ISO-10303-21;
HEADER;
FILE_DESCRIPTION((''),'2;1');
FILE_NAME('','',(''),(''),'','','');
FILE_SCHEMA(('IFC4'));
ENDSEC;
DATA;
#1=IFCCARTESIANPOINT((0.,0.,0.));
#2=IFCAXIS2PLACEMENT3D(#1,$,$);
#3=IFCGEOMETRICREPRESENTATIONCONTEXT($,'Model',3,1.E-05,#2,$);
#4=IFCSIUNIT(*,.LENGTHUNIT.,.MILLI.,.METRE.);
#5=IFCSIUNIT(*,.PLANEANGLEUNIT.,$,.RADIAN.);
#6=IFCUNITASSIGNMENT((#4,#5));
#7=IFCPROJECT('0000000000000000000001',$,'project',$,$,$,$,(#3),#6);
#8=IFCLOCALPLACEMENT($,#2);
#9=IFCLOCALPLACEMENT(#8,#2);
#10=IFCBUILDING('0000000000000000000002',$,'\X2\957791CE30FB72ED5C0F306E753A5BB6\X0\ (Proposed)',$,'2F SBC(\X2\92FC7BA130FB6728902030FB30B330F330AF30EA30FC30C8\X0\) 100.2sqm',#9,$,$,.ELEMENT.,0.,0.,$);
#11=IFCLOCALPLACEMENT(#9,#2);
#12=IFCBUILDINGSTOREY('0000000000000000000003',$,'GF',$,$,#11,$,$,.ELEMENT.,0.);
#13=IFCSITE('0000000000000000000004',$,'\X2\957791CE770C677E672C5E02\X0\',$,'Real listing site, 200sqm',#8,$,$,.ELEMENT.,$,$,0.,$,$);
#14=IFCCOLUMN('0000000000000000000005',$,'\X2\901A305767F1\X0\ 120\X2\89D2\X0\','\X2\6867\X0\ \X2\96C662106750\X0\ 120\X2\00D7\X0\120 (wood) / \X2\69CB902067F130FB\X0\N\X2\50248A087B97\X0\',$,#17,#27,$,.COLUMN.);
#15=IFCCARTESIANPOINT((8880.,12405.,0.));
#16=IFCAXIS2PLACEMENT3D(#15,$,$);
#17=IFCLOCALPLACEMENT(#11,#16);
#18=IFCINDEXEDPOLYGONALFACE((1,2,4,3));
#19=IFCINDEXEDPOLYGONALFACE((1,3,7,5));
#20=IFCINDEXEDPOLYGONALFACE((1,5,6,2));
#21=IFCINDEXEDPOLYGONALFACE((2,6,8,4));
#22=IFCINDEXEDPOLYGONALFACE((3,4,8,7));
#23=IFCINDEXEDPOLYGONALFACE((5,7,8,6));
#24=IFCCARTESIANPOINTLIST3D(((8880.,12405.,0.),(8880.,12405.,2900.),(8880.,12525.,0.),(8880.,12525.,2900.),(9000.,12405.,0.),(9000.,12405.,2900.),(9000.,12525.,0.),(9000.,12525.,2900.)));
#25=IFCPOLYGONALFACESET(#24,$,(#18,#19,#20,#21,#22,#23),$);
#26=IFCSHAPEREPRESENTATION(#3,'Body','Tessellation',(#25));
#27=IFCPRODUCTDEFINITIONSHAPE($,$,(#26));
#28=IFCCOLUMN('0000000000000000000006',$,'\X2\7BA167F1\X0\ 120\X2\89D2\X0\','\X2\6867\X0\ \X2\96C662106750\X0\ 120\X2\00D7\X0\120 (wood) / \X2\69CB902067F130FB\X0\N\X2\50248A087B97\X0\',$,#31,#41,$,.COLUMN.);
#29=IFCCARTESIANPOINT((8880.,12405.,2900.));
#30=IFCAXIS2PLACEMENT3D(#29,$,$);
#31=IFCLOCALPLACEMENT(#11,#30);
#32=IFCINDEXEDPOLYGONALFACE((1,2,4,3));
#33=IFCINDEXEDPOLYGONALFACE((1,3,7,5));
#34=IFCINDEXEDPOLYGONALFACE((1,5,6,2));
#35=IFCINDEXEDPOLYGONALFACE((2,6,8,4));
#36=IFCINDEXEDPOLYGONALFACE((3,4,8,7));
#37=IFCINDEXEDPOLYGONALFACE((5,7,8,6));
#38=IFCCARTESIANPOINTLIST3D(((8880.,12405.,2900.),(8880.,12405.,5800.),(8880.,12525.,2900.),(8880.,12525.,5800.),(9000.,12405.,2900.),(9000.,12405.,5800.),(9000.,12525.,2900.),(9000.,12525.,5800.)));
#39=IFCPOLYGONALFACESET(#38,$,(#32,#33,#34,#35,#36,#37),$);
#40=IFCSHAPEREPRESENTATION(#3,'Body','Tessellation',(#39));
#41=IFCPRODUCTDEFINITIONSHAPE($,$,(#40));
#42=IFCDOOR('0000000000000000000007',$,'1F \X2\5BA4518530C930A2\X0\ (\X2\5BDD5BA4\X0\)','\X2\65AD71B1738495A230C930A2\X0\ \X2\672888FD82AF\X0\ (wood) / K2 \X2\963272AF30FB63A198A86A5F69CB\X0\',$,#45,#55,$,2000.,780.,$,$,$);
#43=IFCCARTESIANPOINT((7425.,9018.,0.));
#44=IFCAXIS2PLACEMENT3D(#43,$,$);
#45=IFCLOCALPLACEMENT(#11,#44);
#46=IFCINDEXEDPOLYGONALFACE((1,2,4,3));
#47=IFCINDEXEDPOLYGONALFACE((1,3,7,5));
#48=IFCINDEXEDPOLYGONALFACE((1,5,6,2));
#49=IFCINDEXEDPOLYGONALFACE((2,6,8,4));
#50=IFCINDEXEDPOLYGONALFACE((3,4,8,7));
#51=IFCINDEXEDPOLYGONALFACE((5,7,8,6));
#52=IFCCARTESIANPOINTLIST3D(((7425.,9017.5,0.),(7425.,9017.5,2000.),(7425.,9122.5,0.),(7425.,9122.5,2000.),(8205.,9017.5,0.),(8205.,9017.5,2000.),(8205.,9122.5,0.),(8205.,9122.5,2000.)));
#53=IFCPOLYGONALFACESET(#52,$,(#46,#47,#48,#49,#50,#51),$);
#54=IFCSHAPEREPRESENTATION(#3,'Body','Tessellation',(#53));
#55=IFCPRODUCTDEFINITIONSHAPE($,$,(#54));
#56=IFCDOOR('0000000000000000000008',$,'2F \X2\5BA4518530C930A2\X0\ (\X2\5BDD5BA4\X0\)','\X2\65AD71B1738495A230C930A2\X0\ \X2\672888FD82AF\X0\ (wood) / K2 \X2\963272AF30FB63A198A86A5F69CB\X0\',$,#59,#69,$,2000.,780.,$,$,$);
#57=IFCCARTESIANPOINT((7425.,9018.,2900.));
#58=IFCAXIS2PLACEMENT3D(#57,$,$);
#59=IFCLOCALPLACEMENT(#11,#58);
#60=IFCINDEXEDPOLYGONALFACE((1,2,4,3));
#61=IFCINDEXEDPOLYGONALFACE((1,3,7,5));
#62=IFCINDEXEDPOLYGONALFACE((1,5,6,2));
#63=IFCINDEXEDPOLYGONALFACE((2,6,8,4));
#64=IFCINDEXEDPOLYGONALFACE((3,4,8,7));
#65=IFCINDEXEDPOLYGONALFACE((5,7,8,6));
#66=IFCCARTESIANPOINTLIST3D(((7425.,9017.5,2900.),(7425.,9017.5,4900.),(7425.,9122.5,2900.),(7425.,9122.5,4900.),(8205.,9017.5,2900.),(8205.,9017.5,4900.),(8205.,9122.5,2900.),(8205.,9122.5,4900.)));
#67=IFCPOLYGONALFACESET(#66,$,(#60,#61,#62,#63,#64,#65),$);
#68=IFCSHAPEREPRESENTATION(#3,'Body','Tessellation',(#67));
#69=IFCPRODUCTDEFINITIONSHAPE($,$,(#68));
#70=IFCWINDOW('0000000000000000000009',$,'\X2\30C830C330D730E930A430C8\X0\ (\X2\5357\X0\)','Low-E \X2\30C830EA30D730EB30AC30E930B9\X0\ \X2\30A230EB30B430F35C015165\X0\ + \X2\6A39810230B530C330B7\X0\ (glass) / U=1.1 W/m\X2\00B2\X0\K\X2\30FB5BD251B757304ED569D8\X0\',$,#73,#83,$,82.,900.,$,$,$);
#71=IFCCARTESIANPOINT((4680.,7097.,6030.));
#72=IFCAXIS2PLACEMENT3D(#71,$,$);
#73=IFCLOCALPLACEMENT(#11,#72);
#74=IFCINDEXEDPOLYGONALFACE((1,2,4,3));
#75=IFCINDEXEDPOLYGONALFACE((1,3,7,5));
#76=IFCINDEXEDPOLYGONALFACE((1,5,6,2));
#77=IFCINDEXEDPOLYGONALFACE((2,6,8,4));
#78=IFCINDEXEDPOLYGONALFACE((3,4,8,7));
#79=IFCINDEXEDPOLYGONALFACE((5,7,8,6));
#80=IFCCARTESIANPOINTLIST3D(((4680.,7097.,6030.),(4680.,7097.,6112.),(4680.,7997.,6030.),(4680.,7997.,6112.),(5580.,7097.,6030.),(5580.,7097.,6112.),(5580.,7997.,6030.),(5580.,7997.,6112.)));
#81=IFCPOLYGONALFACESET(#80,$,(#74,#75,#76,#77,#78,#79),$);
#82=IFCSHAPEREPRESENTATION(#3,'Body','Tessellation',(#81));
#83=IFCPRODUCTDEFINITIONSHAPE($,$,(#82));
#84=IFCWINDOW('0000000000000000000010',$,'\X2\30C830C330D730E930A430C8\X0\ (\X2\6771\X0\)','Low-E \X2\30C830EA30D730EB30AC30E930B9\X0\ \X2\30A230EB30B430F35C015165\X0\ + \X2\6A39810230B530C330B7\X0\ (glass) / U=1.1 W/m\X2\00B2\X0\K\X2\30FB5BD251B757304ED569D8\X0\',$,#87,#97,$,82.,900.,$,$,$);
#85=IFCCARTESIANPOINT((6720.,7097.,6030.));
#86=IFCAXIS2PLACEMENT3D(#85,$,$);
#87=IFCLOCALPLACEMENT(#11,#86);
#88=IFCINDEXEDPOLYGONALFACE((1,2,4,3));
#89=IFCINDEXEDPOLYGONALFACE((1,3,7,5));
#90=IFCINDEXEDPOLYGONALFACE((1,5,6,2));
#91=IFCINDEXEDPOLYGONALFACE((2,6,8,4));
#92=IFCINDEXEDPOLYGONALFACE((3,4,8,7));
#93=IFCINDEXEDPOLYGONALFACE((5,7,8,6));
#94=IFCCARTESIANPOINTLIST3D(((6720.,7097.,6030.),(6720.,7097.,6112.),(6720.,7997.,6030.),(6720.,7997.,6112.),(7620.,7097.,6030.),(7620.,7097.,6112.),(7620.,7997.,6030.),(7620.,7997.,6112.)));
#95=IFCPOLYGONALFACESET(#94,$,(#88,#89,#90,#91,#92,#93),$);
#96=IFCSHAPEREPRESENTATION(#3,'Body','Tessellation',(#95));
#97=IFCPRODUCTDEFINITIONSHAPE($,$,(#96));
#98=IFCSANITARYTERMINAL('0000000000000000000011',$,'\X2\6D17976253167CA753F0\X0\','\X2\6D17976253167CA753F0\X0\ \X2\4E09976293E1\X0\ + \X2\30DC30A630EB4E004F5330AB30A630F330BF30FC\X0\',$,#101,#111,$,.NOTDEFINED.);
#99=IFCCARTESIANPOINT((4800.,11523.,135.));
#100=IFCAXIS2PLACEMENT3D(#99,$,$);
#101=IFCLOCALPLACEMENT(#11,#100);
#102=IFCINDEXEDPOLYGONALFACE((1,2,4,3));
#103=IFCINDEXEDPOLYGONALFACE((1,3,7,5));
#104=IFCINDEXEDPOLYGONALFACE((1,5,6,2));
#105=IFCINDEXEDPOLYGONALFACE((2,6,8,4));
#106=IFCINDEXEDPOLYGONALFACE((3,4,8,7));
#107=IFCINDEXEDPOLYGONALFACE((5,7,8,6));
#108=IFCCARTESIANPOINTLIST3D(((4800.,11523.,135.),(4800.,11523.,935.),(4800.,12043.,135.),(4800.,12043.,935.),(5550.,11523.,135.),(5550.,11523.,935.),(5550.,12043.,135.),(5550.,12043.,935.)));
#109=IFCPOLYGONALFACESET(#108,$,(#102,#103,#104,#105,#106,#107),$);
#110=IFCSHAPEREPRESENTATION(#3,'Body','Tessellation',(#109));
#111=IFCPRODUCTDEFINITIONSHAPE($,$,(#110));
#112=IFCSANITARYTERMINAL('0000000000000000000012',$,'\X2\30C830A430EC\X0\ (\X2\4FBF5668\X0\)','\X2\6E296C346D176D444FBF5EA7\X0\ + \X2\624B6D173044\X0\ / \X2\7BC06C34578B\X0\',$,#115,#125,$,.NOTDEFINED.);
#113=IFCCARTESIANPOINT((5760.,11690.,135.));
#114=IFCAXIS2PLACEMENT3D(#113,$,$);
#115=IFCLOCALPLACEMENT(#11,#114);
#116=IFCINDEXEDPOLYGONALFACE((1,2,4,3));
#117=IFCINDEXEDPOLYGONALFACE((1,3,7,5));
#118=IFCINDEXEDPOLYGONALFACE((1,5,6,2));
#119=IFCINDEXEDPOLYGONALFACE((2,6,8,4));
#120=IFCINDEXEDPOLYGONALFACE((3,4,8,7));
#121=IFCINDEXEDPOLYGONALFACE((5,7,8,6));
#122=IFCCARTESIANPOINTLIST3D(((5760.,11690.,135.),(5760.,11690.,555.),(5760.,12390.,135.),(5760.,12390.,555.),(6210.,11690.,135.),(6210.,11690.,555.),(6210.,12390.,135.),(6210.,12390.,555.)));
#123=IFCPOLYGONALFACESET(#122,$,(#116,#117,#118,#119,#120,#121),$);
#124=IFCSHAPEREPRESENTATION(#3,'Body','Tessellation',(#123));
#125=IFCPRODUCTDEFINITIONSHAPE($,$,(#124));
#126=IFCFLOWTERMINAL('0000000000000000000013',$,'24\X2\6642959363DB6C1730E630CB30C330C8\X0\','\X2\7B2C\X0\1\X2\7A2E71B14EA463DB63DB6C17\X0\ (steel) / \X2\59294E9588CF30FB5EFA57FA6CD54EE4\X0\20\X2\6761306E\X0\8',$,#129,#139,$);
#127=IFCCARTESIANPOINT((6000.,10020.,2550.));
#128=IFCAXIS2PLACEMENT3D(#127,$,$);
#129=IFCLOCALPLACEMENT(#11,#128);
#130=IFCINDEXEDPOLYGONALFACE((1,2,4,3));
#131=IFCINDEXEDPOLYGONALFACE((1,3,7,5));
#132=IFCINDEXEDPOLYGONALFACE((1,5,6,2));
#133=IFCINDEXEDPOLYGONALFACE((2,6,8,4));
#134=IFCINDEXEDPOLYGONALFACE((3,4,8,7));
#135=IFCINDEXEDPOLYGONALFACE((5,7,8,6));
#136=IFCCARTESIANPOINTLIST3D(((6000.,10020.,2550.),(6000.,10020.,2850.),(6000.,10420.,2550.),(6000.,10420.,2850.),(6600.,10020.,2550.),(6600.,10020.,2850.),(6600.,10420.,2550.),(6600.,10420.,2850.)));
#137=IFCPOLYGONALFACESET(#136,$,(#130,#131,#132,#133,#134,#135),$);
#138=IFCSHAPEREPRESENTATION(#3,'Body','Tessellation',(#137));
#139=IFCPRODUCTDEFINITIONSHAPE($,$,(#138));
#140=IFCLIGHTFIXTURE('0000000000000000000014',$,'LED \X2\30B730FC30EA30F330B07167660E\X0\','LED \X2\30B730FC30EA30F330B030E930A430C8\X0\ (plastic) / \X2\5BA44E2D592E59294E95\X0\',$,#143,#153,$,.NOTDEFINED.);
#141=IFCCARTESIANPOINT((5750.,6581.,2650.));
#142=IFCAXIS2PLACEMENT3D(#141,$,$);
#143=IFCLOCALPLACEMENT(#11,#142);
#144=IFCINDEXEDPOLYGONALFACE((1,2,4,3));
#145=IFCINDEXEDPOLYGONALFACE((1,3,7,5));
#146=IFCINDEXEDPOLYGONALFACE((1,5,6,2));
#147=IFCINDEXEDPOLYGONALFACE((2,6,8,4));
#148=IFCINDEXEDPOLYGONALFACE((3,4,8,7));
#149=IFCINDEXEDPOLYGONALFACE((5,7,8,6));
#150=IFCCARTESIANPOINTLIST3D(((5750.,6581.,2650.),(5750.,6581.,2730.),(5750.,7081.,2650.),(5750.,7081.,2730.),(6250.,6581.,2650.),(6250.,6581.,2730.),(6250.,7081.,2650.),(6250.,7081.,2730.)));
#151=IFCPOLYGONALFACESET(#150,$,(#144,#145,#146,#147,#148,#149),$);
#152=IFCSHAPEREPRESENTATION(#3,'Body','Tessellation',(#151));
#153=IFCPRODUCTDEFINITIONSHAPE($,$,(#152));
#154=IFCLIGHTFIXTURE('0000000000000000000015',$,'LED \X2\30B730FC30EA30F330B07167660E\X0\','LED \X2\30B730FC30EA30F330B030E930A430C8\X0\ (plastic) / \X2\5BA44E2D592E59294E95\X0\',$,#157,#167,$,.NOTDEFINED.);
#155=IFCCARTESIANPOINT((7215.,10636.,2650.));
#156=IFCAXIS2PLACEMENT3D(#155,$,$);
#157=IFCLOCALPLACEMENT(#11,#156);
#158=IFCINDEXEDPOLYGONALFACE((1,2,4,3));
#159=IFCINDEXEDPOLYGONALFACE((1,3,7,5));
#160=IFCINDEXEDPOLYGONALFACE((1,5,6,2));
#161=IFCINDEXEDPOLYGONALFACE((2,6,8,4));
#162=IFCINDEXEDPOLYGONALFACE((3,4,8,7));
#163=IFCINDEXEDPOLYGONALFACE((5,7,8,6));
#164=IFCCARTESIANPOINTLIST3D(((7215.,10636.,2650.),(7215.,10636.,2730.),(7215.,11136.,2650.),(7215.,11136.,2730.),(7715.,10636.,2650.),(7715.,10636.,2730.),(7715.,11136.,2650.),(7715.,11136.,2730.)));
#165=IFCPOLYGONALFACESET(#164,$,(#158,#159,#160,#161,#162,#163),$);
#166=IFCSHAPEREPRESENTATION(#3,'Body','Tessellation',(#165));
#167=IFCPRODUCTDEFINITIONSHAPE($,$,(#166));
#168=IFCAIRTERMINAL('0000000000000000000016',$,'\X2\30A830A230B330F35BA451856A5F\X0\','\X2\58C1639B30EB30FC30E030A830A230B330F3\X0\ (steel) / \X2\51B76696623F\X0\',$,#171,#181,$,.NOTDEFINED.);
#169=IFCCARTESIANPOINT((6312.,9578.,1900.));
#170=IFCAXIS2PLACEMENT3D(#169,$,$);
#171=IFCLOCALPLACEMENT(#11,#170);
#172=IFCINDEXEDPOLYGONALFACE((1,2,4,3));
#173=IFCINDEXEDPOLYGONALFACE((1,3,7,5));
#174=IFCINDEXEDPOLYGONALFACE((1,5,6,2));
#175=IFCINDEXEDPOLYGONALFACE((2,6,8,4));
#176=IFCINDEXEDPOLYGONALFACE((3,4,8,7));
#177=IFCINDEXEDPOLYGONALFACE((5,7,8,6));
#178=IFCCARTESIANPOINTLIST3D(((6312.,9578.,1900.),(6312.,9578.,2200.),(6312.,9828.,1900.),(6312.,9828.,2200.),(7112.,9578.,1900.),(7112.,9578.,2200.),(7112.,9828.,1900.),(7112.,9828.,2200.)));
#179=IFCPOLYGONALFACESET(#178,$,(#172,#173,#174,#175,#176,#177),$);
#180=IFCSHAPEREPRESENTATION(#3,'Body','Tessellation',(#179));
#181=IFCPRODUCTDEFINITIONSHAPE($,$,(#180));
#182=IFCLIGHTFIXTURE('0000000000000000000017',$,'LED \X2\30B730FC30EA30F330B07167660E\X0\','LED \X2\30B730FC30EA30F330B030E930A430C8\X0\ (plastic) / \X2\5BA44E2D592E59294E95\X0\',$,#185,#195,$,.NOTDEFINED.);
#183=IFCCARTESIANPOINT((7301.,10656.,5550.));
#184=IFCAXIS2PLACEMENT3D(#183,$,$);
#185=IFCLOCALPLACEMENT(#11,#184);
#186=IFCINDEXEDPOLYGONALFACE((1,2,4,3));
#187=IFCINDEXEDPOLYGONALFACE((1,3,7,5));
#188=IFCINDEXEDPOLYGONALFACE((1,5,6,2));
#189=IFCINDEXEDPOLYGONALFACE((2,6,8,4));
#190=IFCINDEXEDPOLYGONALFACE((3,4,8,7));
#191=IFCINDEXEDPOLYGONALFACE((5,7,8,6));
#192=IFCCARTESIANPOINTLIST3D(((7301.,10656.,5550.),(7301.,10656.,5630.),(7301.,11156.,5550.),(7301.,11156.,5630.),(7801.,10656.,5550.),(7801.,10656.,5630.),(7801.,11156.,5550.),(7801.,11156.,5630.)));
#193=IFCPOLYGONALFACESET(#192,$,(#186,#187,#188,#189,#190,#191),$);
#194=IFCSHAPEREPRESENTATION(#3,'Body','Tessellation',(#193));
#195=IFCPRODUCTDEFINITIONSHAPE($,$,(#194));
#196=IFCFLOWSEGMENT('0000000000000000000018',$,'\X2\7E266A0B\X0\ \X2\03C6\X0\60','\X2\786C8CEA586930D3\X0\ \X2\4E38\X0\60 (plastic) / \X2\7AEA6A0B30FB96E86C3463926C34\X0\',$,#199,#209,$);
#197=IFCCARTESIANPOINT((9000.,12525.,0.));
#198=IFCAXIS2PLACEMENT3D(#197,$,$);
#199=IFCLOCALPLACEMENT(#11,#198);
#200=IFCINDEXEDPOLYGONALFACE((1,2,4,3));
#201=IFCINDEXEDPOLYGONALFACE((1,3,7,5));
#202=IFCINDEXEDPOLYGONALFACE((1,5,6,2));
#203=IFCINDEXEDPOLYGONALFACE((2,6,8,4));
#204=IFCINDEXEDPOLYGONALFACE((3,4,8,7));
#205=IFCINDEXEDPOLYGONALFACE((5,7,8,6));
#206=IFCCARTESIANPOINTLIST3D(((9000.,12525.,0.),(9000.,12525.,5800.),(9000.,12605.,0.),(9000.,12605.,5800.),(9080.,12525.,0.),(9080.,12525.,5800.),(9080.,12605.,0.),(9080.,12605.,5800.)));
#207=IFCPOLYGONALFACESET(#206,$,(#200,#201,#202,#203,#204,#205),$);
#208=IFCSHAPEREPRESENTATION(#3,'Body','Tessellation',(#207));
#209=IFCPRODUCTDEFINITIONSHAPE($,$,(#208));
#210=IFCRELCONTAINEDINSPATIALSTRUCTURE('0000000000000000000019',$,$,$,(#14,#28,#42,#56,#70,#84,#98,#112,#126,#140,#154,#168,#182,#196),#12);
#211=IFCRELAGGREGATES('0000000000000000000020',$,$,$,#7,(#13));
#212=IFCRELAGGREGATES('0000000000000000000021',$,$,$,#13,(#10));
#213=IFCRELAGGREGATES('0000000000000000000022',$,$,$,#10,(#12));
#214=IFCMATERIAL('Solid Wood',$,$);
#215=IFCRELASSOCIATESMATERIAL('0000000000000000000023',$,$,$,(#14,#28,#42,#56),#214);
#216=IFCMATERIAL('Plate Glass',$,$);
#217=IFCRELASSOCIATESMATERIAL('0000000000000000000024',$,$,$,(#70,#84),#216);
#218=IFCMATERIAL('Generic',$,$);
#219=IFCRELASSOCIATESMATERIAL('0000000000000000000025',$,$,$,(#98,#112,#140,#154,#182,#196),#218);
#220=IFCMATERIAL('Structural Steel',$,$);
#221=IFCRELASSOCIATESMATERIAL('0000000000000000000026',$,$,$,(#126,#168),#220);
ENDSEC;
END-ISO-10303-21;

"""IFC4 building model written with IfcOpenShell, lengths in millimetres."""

from ifc_helpers import new_model, si_unit, frame, frame_2d, origin, place, context, project, spatial, rectangle, extrude, material, element, save


model = new_model("IFC4")

# Units and contexts
model_context = context("Model", 3, precision=1e-05, world=origin())
ifc_project = project(units=[si_unit("LENGTHUNIT", "METRE", prefix="MILLI"), si_unit("PLANEANGLEUNIT", "RADIAN")], contexts=[model_context])

# Site, building, storey
site_placement = place(None, origin())
site = spatial("IfcSite", under=ifc_project, at=site_placement, Name="長野県松本市", ObjectType="Real listing site, 200sqm", CompositionType="ELEMENT", RefElevation=0.0)
building_placement = place(site_placement, origin())
building = spatial("IfcBuilding", under=site, at=building_placement, Name="長野・狭小の町家 (Proposed)", ObjectType="2F SBC(鋼管・木造・コンクリート) 100.2sqm", CompositionType="ELEMENT", ElevationOfRefHeight=0.0, ElevationOfTerrain=0.0)
storey_placement = place(building_placement, origin())
storey = spatial("IfcBuildingStorey", under=building, at=storey_placement, Name="GF", CompositionType="ELEMENT", Elevation=0.0)

# Columns
ifc_material_1 = material(Name="Solid Wood")
column_1_placement = place(storey_placement, frame((8880.0, 12405.0, 0.0)))
element("IfcColumn", 1, at=column_1_placement, inside=storey, material=ifc_material_1, Name="通し柱 120角", Description="桧 集成材 120×120 (wood) / 構造柱・N値計算", PredefinedType="COLUMN", context=model_context, shape_type="SweptSolid", body=[
    extrude(rectangle(XDim=120.0, YDim=120.0, at=frame_2d((60.0, 60.0))), frame((8880.0, 12405.0, 0.0)), (0.0, 0.0, 1.0), 2900.0),
])
column_2_placement = place(storey_placement, frame((8880.0, 12405.0, 2900.0)))
element("IfcColumn", 2, at=column_2_placement, inside=storey, material=ifc_material_1, Name="管柱 120角", Description="桧 集成材 120×120 (wood) / 構造柱・N値計算", PredefinedType="COLUMN", context=model_context, shape_type="SweptSolid", body=[
    extrude(rectangle(XDim=120.0, YDim=120.0, at=frame_2d((60.0, 60.0))), frame((8880.0, 12405.0, 2900.0)), (0.0, 0.0, 1.0), 2900.0),
])

# Door
door_1_placement = place(storey_placement, frame((7425.0, 9018.0, 0.0)))
element("IfcDoor", 3, at=door_1_placement, inside=storey, material=ifc_material_1, Name="1F 室内ドア (寝室)", Description="断熱玄関ドア 木製芯 (wood) / K2 防犯・採風機構", OverallHeight=2000.0, OverallWidth=780.0, context=model_context, shape_type="SweptSolid", body=[
    extrude(rectangle(XDim=780.0, YDim=105.0, at=frame_2d((390.0, 52.0))), frame((7425.0, 9018.0, 0.0)), (0.0, 0.0, 1.0), 2000.0),
])

# Door
door_2_placement = place(storey_placement, frame((7425.0, 9018.0, 2900.0)))
element("IfcDoor", 4, at=door_2_placement, inside=storey, material=ifc_material_1, Name="2F 室内ドア (寝室)", Description="断熱玄関ドア 木製芯 (wood) / K2 防犯・採風機構", OverallHeight=2000.0, OverallWidth=780.0, context=model_context, shape_type="SweptSolid", body=[
    extrude(rectangle(XDim=780.0, YDim=105.0, at=frame_2d((390.0, 52.0))), frame((7425.0, 9018.0, 2900.0)), (0.0, 0.0, 1.0), 2000.0),
])

# Windows
ifc_material_2 = material(Name="Plate Glass")
window_1_placement = place(storey_placement, frame((4680.0, 7097.0, 6030.0)))
element("IfcWindow", 5, at=window_1_placement, inside=storey, material=ifc_material_2, Name="トップライト (南)", Description="Low-E トリプルガラス アルゴン封入 + 樹脂サッシ (glass) / U=1.1 W/m²K・寒冷地仕様", OverallHeight=82.0, OverallWidth=900.0, context=model_context, shape_type="SweptSolid", body=[
    extrude(rectangle(XDim=900.0, YDim=900.0, at=frame_2d((450.0, 450.0))), frame((4680.0, 7097.0, 6030.0)), (0.0, 0.0, 1.0), 82.0),
])
window_2_placement = place(storey_placement, frame((6720.0, 7097.0, 6030.0)))
element("IfcWindow", 6, at=window_2_placement, inside=storey, material=ifc_material_2, Name="トップライト (東)", Description="Low-E トリプルガラス アルゴン封入 + 樹脂サッシ (glass) / U=1.1 W/m²K・寒冷地仕様", OverallHeight=82.0, OverallWidth=900.0, context=model_context, shape_type="SweptSolid", body=[
    extrude(rectangle(XDim=900.0, YDim=900.0, at=frame_2d((450.0, 450.0))), frame((6720.0, 7097.0, 6030.0)), (0.0, 0.0, 1.0), 82.0),
])

# Sanitary terminals
ifc_material_3 = material(Name="Generic")
sanitary_terminal_1_placement = place(storey_placement, frame((4800.0, 11523.0, 135.0)))
element("IfcSanitaryTerminal", 7, at=sanitary_terminal_1_placement, inside=storey, material=ifc_material_3, Name="洗面化粧台", Description="洗面化粧台 三面鏡 + ボウル一体カウンター", PredefinedType="NOTDEFINED", context=model_context, shape_type="SweptSolid", body=[
    extrude(rectangle(XDim=750.0, YDim=520.0, at=frame_2d((375.0, 260.0))), frame((4800.0, 11523.0, 135.0)), (0.0, 0.0, 1.0), 800.0),
])
sanitary_terminal_2_placement = place(storey_placement, frame((5760.0, 11690.0, 135.0)))
element("IfcSanitaryTerminal", 8, at=sanitary_terminal_2_placement, inside=storey, material=ifc_material_3, Name="トイレ (便器)", Description="温水洗浄便座 + 手洗い / 節水型", PredefinedType="NOTDEFINED", context=model_context, shape_type="SweptSolid", body=[
    extrude(rectangle(XDim=450.0, YDim=700.0, at=frame_2d((225.0, 350.0))), frame((5760.0, 11690.0, 135.0)), (0.0, 0.0, 1.0), 420.0),
])

# Flow terminal
ifc_material_4 = material(Name="Structural Steel")
flow_terminal_placement = place(storey_placement, frame((6000.0, 10020.0, 2550.0)))
element("IfcFlowTerminal", 9, at=flow_terminal_placement, inside=storey, material=ifc_material_4, Name="24時間換気ユニット", Description="第1種熱交換換気 (steel) / 天井裏・建基法令20条の8", context=model_context, shape_type="SweptSolid", body=[
    extrude(rectangle(XDim=600.0, YDim=400.0, at=frame_2d((300.0, 200.0))), frame((6000.0, 10020.0, 2550.0)), (0.0, 0.0, 1.0), 300.0),
])

# Light fixtures
light_fixture_1_placement = place(storey_placement, frame((5750.0, 6581.0, 2650.0)))
element("IfcLightFixture", 10, at=light_fixture_1_placement, inside=storey, material=ifc_material_3, Name="LED シーリング照明", Description="LED シーリングライト (plastic) / 室中央天井", PredefinedType="NOTDEFINED", context=model_context, shape_type="SweptSolid", body=[
    extrude(rectangle(XDim=500.0, YDim=500.0, at=frame_2d((250.0, 250.0))), frame((5750.0, 6581.0, 2650.0)), (0.0, 0.0, 1.0), 80.0),
])
light_fixture_2_placement = place(storey_placement, frame((7215.0, 10636.0, 2650.0)))
element("IfcLightFixture", 11, at=light_fixture_2_placement, inside=storey, material=ifc_material_3, Name="LED シーリング照明", Description="LED シーリングライト (plastic) / 室中央天井", PredefinedType="NOTDEFINED", context=model_context, shape_type="SweptSolid", body=[
    extrude(rectangle(XDim=500.0, YDim=500.0, at=frame_2d((250.0, 250.0))), frame((7215.0, 10636.0, 2650.0)), (0.0, 0.0, 1.0), 80.0),
])

# Air terminal
air_terminal_placement = place(storey_placement, frame((6312.0, 9578.0, 1900.0)))
element("IfcAirTerminal", 12, at=air_terminal_placement, inside=storey, material=ifc_material_4, Name="エアコン室内機", Description="壁掛ルームエアコン (steel) / 冷暖房", PredefinedType="NOTDEFINED", context=model_context, shape_type="SweptSolid", body=[
    extrude(rectangle(XDim=800.0, YDim=250.0, at=frame_2d((400.0, 125.0))), frame((6312.0, 9578.0, 1900.0)), (0.0, 0.0, 1.0), 300.0),
])

# Light fixture
light_fixture_3_placement = place(storey_placement, frame((7301.0, 10656.0, 5550.0)))
element("IfcLightFixture", 13, at=light_fixture_3_placement, inside=storey, material=ifc_material_3, Name="LED シーリング照明", Description="LED シーリングライト (plastic) / 室中央天井", PredefinedType="NOTDEFINED", context=model_context, shape_type="SweptSolid", body=[
    extrude(rectangle(XDim=500.0, YDim=500.0, at=frame_2d((250.0, 250.0))), frame((7301.0, 10656.0, 5550.0)), (0.0, 0.0, 1.0), 80.0),
])

# Flow segment
flow_segment_placement = place(storey_placement, frame((9000.0, 12525.0, 0.0)))
element("IfcFlowSegment", 14, at=flow_segment_placement, inside=storey, material=ifc_material_3, Name="縦樋 φ60", Description="硬質塩ビ 丸60 (plastic) / 竪樋・雨水排水", context=model_context, shape_type="SweptSolid", body=[
    extrude(rectangle(XDim=80.0, YDim=80.0, at=frame_2d((40.0, 40.0))), frame((9000.0, 12525.0, 0.0)), (0.0, 0.0, 1.0), 5800.0),
])

save(model, "model.ifc")
